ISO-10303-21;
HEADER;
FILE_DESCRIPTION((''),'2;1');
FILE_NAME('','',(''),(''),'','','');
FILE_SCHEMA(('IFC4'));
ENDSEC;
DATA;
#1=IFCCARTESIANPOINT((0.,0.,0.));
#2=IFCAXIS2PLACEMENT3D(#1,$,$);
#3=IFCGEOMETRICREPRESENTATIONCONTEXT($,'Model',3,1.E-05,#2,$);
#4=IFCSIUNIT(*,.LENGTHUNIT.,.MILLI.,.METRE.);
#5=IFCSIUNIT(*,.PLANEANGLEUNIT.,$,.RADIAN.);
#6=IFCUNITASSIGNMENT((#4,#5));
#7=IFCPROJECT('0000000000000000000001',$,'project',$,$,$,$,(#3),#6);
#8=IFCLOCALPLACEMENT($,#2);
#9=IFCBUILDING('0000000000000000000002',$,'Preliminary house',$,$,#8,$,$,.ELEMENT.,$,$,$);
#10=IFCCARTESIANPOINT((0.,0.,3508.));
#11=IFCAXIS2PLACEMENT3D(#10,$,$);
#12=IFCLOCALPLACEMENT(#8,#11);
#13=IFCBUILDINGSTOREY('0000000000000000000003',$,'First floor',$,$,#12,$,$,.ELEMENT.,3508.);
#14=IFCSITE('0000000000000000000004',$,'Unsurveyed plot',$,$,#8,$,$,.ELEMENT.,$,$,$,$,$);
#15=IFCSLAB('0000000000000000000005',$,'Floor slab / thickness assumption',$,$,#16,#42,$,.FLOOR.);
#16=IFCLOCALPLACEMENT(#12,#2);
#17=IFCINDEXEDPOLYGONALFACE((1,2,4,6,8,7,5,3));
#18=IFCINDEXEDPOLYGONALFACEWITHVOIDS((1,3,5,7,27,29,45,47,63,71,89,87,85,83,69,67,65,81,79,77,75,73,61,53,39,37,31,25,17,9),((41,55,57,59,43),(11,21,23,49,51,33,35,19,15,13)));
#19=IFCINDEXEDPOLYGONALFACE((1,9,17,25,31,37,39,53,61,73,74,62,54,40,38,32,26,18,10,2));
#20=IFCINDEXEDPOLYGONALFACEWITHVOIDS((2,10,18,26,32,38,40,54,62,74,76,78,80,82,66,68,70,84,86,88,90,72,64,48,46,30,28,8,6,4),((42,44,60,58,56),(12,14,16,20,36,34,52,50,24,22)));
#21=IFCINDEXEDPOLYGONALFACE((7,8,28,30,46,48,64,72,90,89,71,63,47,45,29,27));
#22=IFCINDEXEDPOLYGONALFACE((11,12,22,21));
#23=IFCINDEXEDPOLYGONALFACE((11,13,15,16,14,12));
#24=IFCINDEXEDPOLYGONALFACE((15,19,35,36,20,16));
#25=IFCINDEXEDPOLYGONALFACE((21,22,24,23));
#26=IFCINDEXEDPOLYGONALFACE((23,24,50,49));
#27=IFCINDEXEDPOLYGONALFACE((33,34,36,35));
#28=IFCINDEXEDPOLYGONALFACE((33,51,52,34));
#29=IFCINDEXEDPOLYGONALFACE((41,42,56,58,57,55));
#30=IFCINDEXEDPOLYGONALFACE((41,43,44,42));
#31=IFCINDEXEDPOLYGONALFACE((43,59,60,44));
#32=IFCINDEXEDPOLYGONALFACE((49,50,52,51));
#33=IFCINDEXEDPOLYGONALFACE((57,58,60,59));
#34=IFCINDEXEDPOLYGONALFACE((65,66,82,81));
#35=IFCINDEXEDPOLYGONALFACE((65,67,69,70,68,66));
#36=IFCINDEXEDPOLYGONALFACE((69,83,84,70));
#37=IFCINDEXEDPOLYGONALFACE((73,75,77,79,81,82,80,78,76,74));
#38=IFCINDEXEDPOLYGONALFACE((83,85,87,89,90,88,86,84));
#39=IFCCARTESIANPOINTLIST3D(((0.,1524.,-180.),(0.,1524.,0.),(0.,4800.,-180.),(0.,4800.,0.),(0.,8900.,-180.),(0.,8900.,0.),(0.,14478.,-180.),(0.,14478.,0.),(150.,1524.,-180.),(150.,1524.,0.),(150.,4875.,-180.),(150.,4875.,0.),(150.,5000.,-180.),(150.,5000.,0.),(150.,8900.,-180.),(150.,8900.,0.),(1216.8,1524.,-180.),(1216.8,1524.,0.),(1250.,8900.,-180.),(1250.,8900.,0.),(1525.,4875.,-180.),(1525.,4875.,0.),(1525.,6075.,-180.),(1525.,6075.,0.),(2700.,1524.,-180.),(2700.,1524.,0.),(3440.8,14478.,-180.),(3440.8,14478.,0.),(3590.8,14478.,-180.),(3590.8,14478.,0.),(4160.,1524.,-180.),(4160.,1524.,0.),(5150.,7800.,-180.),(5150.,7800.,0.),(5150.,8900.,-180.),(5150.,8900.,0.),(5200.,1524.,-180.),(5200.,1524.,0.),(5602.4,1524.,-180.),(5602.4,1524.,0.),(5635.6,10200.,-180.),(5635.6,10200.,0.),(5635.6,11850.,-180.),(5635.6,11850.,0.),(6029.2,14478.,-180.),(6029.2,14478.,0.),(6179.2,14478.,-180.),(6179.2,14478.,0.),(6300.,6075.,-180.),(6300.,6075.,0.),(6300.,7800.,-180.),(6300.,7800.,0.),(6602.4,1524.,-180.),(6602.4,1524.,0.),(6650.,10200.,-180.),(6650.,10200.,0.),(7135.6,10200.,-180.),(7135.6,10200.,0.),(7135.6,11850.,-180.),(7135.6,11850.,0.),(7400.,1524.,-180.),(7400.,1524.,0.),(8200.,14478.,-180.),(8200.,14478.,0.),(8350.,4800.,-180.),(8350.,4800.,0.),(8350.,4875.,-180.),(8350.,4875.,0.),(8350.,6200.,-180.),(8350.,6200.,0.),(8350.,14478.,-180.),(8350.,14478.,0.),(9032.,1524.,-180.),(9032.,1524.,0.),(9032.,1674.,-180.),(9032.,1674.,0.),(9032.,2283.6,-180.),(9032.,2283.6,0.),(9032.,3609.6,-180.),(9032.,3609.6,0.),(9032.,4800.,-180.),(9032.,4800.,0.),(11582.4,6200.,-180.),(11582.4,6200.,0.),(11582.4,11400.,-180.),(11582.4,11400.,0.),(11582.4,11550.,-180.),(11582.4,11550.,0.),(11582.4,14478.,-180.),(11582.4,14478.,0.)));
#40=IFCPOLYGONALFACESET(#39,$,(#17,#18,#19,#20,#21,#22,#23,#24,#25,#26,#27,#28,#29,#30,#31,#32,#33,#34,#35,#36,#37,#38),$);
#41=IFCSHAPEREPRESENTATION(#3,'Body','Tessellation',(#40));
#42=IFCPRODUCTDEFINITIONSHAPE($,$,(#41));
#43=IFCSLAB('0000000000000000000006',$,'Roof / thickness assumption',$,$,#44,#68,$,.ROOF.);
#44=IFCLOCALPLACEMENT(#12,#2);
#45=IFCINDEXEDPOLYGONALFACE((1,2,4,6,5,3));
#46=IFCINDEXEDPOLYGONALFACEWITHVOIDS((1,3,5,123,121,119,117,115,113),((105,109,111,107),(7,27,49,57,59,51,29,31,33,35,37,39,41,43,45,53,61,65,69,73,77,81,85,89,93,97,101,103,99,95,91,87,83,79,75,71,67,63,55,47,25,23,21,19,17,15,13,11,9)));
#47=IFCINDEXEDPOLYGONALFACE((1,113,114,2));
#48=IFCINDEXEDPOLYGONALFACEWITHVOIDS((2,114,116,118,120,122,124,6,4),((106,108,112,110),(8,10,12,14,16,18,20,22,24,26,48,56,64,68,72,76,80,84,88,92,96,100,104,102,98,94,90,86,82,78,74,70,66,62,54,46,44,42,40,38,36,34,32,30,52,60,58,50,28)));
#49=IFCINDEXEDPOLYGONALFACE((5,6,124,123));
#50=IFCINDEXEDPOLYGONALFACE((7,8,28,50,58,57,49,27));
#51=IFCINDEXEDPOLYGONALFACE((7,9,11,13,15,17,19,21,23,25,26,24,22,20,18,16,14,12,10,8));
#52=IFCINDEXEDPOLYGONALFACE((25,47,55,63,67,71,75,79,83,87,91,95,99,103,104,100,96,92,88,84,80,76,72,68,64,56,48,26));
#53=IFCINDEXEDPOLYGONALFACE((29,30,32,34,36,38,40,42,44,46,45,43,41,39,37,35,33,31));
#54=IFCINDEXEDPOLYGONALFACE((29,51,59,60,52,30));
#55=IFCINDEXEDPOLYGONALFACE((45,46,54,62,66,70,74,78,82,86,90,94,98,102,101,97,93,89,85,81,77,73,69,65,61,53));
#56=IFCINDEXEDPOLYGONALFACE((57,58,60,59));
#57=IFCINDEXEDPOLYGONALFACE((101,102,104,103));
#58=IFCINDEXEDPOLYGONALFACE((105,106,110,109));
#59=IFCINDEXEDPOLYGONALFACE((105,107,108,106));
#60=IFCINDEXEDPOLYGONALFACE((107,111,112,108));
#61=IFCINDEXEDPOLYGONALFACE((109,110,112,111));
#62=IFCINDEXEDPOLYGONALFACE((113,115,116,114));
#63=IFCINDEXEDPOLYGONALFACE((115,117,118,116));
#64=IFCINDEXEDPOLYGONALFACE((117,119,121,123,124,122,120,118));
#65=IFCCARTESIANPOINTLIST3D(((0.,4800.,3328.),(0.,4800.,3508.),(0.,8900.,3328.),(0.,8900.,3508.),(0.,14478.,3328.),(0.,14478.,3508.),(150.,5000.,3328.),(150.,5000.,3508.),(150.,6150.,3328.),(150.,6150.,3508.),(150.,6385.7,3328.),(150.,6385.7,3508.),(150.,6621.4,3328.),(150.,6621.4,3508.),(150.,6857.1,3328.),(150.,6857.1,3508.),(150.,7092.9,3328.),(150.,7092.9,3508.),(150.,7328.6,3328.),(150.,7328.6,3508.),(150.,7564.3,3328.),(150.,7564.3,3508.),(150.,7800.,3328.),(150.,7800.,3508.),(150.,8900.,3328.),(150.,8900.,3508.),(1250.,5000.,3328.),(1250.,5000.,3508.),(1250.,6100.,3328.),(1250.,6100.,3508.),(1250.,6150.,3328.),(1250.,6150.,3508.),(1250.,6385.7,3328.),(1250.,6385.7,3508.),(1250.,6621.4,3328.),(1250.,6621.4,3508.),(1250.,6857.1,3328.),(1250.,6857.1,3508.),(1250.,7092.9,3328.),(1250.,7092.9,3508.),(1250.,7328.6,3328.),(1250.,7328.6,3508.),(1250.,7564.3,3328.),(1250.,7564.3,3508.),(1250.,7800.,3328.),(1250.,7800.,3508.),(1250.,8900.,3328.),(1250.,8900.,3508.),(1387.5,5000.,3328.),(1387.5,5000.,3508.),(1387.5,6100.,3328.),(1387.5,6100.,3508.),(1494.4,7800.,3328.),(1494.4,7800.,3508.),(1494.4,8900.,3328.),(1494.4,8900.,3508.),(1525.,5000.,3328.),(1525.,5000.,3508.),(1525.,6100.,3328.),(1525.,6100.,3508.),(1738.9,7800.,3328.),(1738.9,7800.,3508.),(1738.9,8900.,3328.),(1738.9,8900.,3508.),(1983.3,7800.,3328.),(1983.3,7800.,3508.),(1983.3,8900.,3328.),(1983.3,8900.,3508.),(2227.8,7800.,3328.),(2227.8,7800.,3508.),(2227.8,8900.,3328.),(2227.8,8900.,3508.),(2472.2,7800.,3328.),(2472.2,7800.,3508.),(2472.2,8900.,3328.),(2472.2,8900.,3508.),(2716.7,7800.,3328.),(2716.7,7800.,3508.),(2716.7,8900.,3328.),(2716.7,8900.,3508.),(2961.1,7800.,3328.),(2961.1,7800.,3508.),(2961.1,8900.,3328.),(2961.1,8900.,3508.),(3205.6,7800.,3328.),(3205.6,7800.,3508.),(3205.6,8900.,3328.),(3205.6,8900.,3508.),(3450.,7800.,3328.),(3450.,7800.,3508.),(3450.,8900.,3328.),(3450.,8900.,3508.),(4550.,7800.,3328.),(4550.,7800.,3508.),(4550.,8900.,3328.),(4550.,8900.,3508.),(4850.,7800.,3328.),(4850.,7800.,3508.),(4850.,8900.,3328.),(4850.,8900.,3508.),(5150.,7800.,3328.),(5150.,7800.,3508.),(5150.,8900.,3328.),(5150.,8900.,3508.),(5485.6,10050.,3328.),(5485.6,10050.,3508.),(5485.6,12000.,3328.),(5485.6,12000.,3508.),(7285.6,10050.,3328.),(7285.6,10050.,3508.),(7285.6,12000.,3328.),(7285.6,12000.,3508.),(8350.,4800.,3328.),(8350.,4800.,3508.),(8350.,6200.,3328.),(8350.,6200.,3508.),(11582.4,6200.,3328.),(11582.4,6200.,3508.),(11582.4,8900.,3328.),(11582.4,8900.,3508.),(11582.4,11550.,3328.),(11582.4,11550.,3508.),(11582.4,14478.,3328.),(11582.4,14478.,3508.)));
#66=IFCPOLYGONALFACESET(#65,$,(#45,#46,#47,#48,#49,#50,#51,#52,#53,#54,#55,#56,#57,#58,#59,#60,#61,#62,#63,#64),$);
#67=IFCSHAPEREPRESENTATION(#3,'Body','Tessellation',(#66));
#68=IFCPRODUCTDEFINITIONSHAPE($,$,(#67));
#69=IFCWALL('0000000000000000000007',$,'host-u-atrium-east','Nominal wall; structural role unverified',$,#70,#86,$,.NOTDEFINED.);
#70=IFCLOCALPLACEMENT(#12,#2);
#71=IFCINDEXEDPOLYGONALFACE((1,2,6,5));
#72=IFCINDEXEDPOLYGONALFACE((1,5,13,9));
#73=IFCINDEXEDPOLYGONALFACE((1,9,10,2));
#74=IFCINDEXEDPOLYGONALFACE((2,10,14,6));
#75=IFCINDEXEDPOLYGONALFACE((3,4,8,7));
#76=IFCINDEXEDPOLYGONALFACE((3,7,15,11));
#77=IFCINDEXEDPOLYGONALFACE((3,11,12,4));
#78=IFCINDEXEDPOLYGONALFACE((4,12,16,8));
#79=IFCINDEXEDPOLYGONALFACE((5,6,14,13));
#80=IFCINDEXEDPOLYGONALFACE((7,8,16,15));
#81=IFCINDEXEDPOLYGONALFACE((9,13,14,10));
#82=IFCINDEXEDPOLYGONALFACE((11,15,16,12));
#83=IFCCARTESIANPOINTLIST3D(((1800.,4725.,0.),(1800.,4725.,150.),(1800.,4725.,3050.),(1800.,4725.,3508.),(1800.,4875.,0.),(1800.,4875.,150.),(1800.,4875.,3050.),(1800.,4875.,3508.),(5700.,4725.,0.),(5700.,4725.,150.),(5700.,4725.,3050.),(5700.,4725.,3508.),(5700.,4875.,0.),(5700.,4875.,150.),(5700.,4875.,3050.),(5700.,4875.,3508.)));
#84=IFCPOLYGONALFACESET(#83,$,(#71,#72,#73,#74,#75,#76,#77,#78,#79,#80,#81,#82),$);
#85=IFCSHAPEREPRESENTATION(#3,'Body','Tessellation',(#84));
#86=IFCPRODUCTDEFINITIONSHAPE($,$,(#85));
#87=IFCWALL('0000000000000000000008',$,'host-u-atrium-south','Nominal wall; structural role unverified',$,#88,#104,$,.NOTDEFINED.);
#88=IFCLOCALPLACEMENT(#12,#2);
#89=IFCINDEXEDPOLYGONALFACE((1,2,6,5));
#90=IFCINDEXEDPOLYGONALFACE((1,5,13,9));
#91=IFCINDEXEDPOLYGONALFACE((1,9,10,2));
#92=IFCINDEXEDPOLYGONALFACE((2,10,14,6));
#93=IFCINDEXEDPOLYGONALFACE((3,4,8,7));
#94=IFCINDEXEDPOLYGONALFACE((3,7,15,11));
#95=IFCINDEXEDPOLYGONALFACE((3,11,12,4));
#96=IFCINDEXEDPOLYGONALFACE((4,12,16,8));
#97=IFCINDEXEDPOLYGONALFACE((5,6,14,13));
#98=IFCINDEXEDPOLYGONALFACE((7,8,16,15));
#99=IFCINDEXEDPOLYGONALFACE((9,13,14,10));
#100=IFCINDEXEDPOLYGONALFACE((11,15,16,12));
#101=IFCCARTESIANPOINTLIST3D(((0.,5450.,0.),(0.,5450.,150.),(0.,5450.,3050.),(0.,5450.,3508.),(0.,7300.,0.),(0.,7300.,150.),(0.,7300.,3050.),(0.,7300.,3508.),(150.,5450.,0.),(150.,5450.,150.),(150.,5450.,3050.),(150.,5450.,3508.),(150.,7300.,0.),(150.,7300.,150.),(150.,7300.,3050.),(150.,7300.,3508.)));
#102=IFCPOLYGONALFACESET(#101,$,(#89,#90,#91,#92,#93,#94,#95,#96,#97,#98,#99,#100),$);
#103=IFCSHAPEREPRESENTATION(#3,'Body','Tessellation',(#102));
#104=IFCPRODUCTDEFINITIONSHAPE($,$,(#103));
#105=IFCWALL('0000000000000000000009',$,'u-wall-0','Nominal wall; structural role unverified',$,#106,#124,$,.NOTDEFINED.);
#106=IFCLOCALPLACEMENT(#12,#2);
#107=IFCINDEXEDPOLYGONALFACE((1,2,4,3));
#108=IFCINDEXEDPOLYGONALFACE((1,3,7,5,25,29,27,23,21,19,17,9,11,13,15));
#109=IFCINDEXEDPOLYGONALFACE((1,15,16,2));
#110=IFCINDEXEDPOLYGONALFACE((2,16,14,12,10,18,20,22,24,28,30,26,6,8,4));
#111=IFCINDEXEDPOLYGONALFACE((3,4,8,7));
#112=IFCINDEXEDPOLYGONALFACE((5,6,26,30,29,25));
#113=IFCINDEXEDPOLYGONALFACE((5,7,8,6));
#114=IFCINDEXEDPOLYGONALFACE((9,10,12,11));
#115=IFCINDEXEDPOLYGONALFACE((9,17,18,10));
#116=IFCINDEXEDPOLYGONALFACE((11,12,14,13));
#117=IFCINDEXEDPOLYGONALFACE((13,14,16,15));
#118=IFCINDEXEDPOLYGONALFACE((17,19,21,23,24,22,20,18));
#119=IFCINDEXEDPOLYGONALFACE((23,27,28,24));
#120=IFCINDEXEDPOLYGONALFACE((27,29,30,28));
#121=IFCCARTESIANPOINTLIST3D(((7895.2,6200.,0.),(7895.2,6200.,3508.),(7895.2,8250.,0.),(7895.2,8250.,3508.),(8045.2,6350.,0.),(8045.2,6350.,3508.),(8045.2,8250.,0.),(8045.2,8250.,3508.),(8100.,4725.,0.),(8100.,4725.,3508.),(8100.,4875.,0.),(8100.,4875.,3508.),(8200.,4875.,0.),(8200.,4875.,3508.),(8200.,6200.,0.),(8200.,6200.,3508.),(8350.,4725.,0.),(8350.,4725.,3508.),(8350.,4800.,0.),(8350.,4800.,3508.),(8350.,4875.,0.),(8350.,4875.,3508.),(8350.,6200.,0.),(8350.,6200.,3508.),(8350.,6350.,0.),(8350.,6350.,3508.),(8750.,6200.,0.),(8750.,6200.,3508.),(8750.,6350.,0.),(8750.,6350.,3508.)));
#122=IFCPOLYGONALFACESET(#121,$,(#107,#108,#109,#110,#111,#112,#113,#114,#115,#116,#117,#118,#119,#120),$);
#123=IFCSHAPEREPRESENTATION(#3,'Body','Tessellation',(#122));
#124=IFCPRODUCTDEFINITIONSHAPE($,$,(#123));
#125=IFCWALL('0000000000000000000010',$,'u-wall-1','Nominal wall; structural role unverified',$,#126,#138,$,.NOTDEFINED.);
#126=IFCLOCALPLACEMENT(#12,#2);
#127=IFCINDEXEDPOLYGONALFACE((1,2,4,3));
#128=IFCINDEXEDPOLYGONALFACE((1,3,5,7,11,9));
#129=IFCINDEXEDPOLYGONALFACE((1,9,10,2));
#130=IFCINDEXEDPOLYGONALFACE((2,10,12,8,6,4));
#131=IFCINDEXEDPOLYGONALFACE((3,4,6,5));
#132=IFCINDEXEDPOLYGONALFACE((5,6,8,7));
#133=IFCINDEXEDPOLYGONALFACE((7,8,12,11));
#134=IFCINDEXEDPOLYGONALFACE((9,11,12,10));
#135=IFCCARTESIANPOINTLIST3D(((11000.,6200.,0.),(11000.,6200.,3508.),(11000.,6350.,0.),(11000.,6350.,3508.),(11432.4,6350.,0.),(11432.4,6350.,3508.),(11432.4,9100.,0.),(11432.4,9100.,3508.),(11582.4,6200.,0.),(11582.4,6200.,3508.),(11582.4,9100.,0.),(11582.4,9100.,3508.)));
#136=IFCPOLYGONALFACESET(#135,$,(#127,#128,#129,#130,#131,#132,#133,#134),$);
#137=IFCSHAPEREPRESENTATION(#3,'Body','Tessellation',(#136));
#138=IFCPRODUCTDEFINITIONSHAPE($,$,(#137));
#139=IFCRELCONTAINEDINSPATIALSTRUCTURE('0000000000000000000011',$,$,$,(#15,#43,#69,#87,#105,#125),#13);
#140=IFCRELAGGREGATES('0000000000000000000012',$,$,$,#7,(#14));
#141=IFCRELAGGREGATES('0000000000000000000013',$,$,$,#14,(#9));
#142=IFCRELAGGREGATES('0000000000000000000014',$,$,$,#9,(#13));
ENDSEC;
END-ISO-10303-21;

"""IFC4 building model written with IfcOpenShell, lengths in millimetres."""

from ifc_helpers import new_model, si_unit, frame, origin, place, context, project, spatial, polyline, outline, extrude, element, save


model = new_model("IFC4")

# Units and contexts
model_context = context("Model", 3, precision=1e-05, world=origin())
ifc_project = project(units=[si_unit("LENGTHUNIT", "METRE", prefix="MILLI"), si_unit("PLANEANGLEUNIT", "RADIAN")], contexts=[model_context])

# Site, building, storey
placement_1 = place(None, origin())
site = spatial("IfcSite", under=ifc_project, at=placement_1, Name="Unsurveyed plot", CompositionType="ELEMENT")
building = spatial("IfcBuilding", under=site, at=placement_1, Name="Preliminary house", CompositionType="ELEMENT")
placement_2 = place(placement_1, frame((0.0, 0.0, 3508.0)))
storey = spatial("IfcBuildingStorey", under=building, at=placement_2, Name="First floor", CompositionType="ELEMENT", Elevation=3508.0)

# Slabs
element("IfcSlab", 1, at=placement_2, inside=storey, Name="Floor slab / thickness assumption", PredefinedType="FLOOR", context=model_context, shape_type="SweptSolid", body=[
    extrude(outline(polyline([(5602.4, 1524.0), (5200.0, 1524.0), (4160.0, 1524.0), (2700.0, 1524.0), (1216.8, 1524.0), (150.0, 1524.0), (0.0, 1524.0), (0.0, 4800.0), (0.0, 8900.0), (0.0, 14478.0), (3440.8, 14478.0), (3590.8, 14478.0), (6029.2, 14478.0), (6179.2, 14478.0), (8200.0, 14478.0), (8350.0, 14478.0), (11582.4, 14478.0), (11582.4, 11550.0), (11582.4, 11400.0), (11582.4, 6200.0), (8350.0, 6200.0), (8350.0, 4875.0), (8350.0, 4800.0), (9032.0, 4800.0), (9032.0, 3609.6), (9032.0, 2283.6), (9032.0, 1674.0), (9032.0, 1524.0), (7400.0, 1524.0), (6602.4, 1524.0), (5602.4, 1524.0)]), holes=[polyline([(5150.0, 8900.0), (1250.0, 8900.0), (150.0, 8900.0), (150.0, 5000.0), (150.0, 4875.0), (1525.0, 4875.0), (1525.0, 6075.0), (6300.0, 6075.0), (6300.0, 7800.0), (5150.0, 7800.0), (5150.0, 8900.0)]), polyline([(7135.6, 10200.0), (7135.6, 11850.0), (5635.6, 11850.0), (5635.6, 10200.0), (6650.0, 10200.0), (7135.6, 10200.0)])]), frame((0.0, 0.0, -180.0)), (0.0, 0.0, 1.0), 180.0),
])
element("IfcSlab", 2, at=placement_2, inside=storey, Name="Roof / thickness assumption", PredefinedType="ROOF", context=model_context, shape_type="SweptSolid", body=[
    extrude(outline(polyline([(11582.4, 14478.0), (11582.4, 11550.0), (11582.4, 8900.0), (11582.4, 6200.0), (8350.0, 6200.0), (8350.0, 4800.0), (0.0, 4800.0), (0.0, 8900.0), (0.0, 14478.0), (11582.4, 14478.0)]), holes=[polyline([(7285.6, 10050.0), (7285.6, 12000.0), (5485.6, 12000.0), (5485.6, 10050.0), (7285.6, 10050.0)]), polyline([(1387.5, 6100.0), (1250.0, 6100.0), (1250.0, 6150.0), (1250.0, 6385.7), (1250.0, 6621.4), (1250.0, 6857.1), (1250.0, 7092.9), (1250.0, 7328.6), (1250.0, 7564.3), (1250.0, 7800.0), (1494.4, 7800.0), (1738.9, 7800.0), (1983.3, 7800.0), (2227.8, 7800.0), (2472.2, 7800.0), (2716.7, 7800.0), (2961.1, 7800.0), (3205.6, 7800.0), (3450.0, 7800.0), (4550.0, 7800.0), (4850.0, 7800.0), (5150.0, 7800.0), (5150.0, 8900.0), (4850.0, 8900.0), (4550.0, 8900.0), (3450.0, 8900.0), (3205.6, 8900.0), (2961.1, 8900.0), (2716.7, 8900.0), (2472.2, 8900.0), (2227.8, 8900.0), (1983.3, 8900.0), (1738.9, 8900.0), (1494.4, 8900.0), (1250.0, 8900.0), (150.0, 8900.0), (150.0, 7800.0), (150.0, 7564.3), (150.0, 7328.6), (150.0, 7092.9), (150.0, 6857.1), (150.0, 6621.4), (150.0, 6385.7), (150.0, 6150.0), (150.0, 5000.0), (1250.0, 5000.0), (1387.5, 5000.0), (1525.0, 5000.0), (1525.0, 6100.0), (1387.5, 6100.0)])]), frame((0.0, 0.0, 3328.0)), (0.0, 0.0, 1.0), 180.0),
])

# Walls, openings
wall_1 = element("IfcWall", 3, at=placement_2, inside=storey, Name="host-u-atrium-east", Description="Nominal wall; structural role unverified", PredefinedType="NOTDEFINED", context=model_context, shape_type="SweptSolid", body=[
    extrude(outline(polyline([(5700.0, 4875.0), (5700.0, 4725.0), (1800.0, 4725.0), (1800.0, 4875.0), (5700.0, 4875.0)])), origin(), (0.0, 0.0, 1.0), 3508.0),
])
element("IfcOpeningElement", 4, at=placement_2, cuts=wall_1, PredefinedType="OPENING", context=model_context, shape_type="SweptSolid", body=[
    extrude(outline(polyline([(1800.0, 4350.0), (5700.0, 4350.0), (5700.0, 5250.0), (1800.0, 5250.0), (1800.0, 4350.0)])), frame((0.0, 0.0, 150.0)), (0.0, 0.0, 1.0), 2900.0),
])
wall_2 = element("IfcWall", 5, at=placement_2, inside=storey, Name="host-u-atrium-south", Description="Nominal wall; structural role unverified", PredefinedType="NOTDEFINED", context=model_context, shape_type="SweptSolid", body=[
    extrude(outline(polyline([(0.0, 7300.0), (150.0, 7300.0), (150.0, 5450.0), (0.0, 5450.0), (0.0, 7300.0)])), origin(), (0.0, 0.0, 1.0), 3508.0),
])
element("IfcOpeningElement", 6, at=placement_2, cuts=wall_2, PredefinedType="OPENING", context=model_context, shape_type="SweptSolid", body=[
    extrude(outline(polyline([(525.0, 5450.0), (525.0, 7300.0), (-375.0, 7300.0), (-375.0, 5450.0), (525.0, 5450.0)])), frame((0.0, 0.0, 150.0)), (0.0, 0.0, 1.0), 2900.0),
])

# Walls
element("IfcWall", 7, at=placement_2, inside=storey, Name="u-wall-0", Description="Nominal wall; structural role unverified", PredefinedType="NOTDEFINED", context=model_context, shape_type="SweptSolid", body=[
    extrude(outline(polyline([(8350.0, 4875.0), (8350.0, 4800.0), (8350.0, 4725.0), (8100.0, 4725.0), (8100.0, 4875.0), (8200.0, 4875.0), (8200.0, 6200.0), (7895.2, 6200.0), (7895.2, 8250.0), (8045.2, 8250.0), (8045.2, 6350.0), (8350.0, 6350.0), (8750.0, 6350.0), (8750.0, 6200.0), (8350.0, 6200.0), (8350.0, 4875.0)])), origin(), (0.0, 0.0, 1.0), 3508.0),
])
element("IfcWall", 8, at=placement_2, inside=storey, Name="u-wall-1", Description="Nominal wall; structural role unverified", PredefinedType="NOTDEFINED", context=model_context, shape_type="SweptSolid", body=[
    extrude(outline(polyline([(11432.4, 6350.0), (11432.4, 9100.0), (11582.4, 9100.0), (11582.4, 6200.0), (11000.0, 6200.0), (11000.0, 6350.0), (11432.4, 6350.0)])), origin(), (0.0, 0.0, 1.0), 3508.0),
])

save(model, "model.ifc")
